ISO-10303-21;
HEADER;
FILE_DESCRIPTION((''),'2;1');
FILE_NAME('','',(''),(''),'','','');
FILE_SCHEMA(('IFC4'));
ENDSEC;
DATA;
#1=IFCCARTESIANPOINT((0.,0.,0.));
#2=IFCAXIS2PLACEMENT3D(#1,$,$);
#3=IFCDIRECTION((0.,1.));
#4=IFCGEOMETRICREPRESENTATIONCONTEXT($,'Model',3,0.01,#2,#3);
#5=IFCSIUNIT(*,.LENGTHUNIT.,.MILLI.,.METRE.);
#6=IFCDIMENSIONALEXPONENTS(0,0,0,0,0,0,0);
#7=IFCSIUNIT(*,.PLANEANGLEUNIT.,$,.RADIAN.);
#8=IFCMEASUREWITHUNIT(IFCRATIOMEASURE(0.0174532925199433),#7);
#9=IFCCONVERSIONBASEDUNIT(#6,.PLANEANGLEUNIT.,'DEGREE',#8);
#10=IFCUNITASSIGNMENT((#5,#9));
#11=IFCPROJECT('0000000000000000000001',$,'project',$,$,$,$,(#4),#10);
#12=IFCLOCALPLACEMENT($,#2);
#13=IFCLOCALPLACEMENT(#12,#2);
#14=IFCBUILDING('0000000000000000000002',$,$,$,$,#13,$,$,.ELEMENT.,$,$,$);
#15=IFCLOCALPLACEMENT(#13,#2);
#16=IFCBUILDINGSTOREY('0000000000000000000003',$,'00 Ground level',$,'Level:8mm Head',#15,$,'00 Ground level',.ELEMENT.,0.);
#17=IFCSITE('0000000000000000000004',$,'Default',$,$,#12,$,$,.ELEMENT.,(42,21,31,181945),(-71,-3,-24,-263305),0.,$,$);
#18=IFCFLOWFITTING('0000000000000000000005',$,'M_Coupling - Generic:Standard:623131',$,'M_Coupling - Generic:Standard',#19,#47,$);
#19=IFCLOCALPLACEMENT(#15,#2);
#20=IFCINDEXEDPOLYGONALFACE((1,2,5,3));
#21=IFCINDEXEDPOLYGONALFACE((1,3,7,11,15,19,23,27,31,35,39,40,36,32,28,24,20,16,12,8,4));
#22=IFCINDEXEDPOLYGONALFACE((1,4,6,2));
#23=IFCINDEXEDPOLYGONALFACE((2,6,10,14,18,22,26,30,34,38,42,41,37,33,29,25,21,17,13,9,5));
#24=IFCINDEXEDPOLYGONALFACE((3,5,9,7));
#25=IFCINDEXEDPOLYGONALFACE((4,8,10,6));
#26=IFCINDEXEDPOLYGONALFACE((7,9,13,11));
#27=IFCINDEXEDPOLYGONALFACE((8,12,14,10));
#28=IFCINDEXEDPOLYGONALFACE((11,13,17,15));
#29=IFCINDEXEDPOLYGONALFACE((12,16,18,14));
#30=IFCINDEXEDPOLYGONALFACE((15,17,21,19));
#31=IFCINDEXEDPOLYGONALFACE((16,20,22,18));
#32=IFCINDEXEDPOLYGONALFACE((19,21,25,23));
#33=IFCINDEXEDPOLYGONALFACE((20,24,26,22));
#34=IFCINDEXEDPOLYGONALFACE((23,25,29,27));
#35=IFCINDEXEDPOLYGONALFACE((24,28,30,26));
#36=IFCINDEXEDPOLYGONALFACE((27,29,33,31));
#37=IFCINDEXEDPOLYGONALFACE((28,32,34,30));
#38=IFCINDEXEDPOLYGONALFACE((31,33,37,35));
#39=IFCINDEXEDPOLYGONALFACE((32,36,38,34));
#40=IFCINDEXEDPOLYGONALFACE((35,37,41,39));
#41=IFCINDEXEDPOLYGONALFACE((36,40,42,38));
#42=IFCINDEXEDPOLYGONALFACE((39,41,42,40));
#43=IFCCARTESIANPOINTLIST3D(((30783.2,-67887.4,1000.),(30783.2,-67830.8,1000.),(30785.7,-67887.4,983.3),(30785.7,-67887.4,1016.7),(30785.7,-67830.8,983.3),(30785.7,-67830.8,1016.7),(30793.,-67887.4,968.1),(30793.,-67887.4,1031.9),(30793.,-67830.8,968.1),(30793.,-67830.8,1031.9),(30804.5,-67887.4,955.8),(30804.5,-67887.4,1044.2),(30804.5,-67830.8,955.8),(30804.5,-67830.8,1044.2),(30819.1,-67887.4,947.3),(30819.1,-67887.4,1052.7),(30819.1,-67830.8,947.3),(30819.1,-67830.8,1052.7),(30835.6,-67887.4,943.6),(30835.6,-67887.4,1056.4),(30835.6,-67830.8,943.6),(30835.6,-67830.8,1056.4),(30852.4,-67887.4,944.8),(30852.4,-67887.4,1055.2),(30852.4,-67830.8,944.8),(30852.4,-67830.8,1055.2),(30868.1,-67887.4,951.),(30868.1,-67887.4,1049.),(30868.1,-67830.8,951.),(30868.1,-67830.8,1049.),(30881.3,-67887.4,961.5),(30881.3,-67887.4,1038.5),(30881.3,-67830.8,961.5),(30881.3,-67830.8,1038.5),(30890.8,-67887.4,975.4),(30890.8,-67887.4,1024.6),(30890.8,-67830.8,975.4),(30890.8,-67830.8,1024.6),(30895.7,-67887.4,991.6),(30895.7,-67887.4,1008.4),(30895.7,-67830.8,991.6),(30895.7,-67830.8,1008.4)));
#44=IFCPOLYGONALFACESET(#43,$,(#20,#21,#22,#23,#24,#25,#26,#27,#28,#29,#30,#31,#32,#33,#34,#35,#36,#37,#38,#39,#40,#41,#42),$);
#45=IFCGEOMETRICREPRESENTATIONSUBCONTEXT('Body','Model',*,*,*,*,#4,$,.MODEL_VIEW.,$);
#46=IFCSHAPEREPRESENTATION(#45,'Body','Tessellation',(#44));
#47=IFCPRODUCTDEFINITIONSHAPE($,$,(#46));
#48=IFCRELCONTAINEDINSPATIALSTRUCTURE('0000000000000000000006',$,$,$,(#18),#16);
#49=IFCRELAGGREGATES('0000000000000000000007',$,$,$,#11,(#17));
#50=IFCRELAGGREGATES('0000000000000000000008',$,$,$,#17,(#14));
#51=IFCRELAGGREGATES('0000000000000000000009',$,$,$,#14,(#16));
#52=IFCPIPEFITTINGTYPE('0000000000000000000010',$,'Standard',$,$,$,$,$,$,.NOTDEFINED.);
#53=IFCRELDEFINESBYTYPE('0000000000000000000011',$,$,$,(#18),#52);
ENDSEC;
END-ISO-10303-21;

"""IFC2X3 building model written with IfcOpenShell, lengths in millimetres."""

from ifc_helpers import new_model, entity, si_unit, converted_unit, direction, frame, frame_2d, origin, place, context, subcontext, project, spatial, circle, extrude, source, transform, mapped, type_object, type_shapes, element, save


model = new_model("IFC2X3")

# Units and contexts
model_context = context("Model", 3, precision=0.01, world=origin(), true_north=direction((0.0, 1.0)))
body_context = subcontext(model_context, "Body", "Model", "MODEL_VIEW")
ifc_project = project(units=[si_unit("LENGTHUNIT", "METRE", prefix="MILLI"), converted_unit("PLANEANGLEUNIT", "DEGREE", entity("IfcRatioMeasure", 0.0174532925199433), si_unit("PLANEANGLEUNIT", "RADIAN"), dimensions=[0, 0, 0, 0, 0, 0, 0])], contexts=[model_context])

# Site, building, storey
site_placement = place(None, origin())
site = spatial("IfcSite", under=ifc_project, at=site_placement, Name="Default", CompositionType="ELEMENT", RefLatitude=(42, 21, 31, 181945), RefLongitude=(-71, -3, -24, -263305), RefElevation=0.0)
building_placement = place(site_placement, origin())
building = spatial("IfcBuilding", under=site, at=building_placement, CompositionType="ELEMENT")
storey_placement = place(building_placement, origin())
storey = spatial("IfcBuildingStorey", under=building, at=storey_placement, Name="00 Ground level", ObjectType="Level:8mm Head", LongName="00 Ground level", CompositionType="ELEMENT", Elevation=0.0)

# Flow fitting
pipe_fitting_type = type_object("IfcPipeFittingType", Name="Standard", PredefinedType="NOTDEFINED")
shared_shape = source(origin(), body_context, "Body", "SweptSolid", [
    extrude(circle(Radius=56.6, at=frame_2d((0.0, 0.0), x_axis=(1.0, 0.0))), frame((-28.3, 0.0, 0.0), z_axis=(1.0, 0.0, 0.0), x_axis=(0.0, 1.0, 0.0)), (0.0, 0.0, 1.0), 56.6),
])
type_shapes(pipe_fitting_type, [shared_shape])
flow_fitting_placement = place(storey_placement, frame((30839.8, -67859.1, 1000.0), z_axis=(0.0, 0.0, 1.0), x_axis=(0.0, 1.0, 0.0)))
element("IfcFlowFitting", 1, at=flow_fitting_placement, inside=storey, type_object=pipe_fitting_type, Name="M_Coupling - Generic:Standard:623131", ObjectType="M_Coupling - Generic:Standard", context=body_context, shape_type="MappedRepresentation", body=[
    mapped(shared_shape, transform((0.0, 0.0, 0.0), scale=1.0)),
])

save(model, "model.ifc")
